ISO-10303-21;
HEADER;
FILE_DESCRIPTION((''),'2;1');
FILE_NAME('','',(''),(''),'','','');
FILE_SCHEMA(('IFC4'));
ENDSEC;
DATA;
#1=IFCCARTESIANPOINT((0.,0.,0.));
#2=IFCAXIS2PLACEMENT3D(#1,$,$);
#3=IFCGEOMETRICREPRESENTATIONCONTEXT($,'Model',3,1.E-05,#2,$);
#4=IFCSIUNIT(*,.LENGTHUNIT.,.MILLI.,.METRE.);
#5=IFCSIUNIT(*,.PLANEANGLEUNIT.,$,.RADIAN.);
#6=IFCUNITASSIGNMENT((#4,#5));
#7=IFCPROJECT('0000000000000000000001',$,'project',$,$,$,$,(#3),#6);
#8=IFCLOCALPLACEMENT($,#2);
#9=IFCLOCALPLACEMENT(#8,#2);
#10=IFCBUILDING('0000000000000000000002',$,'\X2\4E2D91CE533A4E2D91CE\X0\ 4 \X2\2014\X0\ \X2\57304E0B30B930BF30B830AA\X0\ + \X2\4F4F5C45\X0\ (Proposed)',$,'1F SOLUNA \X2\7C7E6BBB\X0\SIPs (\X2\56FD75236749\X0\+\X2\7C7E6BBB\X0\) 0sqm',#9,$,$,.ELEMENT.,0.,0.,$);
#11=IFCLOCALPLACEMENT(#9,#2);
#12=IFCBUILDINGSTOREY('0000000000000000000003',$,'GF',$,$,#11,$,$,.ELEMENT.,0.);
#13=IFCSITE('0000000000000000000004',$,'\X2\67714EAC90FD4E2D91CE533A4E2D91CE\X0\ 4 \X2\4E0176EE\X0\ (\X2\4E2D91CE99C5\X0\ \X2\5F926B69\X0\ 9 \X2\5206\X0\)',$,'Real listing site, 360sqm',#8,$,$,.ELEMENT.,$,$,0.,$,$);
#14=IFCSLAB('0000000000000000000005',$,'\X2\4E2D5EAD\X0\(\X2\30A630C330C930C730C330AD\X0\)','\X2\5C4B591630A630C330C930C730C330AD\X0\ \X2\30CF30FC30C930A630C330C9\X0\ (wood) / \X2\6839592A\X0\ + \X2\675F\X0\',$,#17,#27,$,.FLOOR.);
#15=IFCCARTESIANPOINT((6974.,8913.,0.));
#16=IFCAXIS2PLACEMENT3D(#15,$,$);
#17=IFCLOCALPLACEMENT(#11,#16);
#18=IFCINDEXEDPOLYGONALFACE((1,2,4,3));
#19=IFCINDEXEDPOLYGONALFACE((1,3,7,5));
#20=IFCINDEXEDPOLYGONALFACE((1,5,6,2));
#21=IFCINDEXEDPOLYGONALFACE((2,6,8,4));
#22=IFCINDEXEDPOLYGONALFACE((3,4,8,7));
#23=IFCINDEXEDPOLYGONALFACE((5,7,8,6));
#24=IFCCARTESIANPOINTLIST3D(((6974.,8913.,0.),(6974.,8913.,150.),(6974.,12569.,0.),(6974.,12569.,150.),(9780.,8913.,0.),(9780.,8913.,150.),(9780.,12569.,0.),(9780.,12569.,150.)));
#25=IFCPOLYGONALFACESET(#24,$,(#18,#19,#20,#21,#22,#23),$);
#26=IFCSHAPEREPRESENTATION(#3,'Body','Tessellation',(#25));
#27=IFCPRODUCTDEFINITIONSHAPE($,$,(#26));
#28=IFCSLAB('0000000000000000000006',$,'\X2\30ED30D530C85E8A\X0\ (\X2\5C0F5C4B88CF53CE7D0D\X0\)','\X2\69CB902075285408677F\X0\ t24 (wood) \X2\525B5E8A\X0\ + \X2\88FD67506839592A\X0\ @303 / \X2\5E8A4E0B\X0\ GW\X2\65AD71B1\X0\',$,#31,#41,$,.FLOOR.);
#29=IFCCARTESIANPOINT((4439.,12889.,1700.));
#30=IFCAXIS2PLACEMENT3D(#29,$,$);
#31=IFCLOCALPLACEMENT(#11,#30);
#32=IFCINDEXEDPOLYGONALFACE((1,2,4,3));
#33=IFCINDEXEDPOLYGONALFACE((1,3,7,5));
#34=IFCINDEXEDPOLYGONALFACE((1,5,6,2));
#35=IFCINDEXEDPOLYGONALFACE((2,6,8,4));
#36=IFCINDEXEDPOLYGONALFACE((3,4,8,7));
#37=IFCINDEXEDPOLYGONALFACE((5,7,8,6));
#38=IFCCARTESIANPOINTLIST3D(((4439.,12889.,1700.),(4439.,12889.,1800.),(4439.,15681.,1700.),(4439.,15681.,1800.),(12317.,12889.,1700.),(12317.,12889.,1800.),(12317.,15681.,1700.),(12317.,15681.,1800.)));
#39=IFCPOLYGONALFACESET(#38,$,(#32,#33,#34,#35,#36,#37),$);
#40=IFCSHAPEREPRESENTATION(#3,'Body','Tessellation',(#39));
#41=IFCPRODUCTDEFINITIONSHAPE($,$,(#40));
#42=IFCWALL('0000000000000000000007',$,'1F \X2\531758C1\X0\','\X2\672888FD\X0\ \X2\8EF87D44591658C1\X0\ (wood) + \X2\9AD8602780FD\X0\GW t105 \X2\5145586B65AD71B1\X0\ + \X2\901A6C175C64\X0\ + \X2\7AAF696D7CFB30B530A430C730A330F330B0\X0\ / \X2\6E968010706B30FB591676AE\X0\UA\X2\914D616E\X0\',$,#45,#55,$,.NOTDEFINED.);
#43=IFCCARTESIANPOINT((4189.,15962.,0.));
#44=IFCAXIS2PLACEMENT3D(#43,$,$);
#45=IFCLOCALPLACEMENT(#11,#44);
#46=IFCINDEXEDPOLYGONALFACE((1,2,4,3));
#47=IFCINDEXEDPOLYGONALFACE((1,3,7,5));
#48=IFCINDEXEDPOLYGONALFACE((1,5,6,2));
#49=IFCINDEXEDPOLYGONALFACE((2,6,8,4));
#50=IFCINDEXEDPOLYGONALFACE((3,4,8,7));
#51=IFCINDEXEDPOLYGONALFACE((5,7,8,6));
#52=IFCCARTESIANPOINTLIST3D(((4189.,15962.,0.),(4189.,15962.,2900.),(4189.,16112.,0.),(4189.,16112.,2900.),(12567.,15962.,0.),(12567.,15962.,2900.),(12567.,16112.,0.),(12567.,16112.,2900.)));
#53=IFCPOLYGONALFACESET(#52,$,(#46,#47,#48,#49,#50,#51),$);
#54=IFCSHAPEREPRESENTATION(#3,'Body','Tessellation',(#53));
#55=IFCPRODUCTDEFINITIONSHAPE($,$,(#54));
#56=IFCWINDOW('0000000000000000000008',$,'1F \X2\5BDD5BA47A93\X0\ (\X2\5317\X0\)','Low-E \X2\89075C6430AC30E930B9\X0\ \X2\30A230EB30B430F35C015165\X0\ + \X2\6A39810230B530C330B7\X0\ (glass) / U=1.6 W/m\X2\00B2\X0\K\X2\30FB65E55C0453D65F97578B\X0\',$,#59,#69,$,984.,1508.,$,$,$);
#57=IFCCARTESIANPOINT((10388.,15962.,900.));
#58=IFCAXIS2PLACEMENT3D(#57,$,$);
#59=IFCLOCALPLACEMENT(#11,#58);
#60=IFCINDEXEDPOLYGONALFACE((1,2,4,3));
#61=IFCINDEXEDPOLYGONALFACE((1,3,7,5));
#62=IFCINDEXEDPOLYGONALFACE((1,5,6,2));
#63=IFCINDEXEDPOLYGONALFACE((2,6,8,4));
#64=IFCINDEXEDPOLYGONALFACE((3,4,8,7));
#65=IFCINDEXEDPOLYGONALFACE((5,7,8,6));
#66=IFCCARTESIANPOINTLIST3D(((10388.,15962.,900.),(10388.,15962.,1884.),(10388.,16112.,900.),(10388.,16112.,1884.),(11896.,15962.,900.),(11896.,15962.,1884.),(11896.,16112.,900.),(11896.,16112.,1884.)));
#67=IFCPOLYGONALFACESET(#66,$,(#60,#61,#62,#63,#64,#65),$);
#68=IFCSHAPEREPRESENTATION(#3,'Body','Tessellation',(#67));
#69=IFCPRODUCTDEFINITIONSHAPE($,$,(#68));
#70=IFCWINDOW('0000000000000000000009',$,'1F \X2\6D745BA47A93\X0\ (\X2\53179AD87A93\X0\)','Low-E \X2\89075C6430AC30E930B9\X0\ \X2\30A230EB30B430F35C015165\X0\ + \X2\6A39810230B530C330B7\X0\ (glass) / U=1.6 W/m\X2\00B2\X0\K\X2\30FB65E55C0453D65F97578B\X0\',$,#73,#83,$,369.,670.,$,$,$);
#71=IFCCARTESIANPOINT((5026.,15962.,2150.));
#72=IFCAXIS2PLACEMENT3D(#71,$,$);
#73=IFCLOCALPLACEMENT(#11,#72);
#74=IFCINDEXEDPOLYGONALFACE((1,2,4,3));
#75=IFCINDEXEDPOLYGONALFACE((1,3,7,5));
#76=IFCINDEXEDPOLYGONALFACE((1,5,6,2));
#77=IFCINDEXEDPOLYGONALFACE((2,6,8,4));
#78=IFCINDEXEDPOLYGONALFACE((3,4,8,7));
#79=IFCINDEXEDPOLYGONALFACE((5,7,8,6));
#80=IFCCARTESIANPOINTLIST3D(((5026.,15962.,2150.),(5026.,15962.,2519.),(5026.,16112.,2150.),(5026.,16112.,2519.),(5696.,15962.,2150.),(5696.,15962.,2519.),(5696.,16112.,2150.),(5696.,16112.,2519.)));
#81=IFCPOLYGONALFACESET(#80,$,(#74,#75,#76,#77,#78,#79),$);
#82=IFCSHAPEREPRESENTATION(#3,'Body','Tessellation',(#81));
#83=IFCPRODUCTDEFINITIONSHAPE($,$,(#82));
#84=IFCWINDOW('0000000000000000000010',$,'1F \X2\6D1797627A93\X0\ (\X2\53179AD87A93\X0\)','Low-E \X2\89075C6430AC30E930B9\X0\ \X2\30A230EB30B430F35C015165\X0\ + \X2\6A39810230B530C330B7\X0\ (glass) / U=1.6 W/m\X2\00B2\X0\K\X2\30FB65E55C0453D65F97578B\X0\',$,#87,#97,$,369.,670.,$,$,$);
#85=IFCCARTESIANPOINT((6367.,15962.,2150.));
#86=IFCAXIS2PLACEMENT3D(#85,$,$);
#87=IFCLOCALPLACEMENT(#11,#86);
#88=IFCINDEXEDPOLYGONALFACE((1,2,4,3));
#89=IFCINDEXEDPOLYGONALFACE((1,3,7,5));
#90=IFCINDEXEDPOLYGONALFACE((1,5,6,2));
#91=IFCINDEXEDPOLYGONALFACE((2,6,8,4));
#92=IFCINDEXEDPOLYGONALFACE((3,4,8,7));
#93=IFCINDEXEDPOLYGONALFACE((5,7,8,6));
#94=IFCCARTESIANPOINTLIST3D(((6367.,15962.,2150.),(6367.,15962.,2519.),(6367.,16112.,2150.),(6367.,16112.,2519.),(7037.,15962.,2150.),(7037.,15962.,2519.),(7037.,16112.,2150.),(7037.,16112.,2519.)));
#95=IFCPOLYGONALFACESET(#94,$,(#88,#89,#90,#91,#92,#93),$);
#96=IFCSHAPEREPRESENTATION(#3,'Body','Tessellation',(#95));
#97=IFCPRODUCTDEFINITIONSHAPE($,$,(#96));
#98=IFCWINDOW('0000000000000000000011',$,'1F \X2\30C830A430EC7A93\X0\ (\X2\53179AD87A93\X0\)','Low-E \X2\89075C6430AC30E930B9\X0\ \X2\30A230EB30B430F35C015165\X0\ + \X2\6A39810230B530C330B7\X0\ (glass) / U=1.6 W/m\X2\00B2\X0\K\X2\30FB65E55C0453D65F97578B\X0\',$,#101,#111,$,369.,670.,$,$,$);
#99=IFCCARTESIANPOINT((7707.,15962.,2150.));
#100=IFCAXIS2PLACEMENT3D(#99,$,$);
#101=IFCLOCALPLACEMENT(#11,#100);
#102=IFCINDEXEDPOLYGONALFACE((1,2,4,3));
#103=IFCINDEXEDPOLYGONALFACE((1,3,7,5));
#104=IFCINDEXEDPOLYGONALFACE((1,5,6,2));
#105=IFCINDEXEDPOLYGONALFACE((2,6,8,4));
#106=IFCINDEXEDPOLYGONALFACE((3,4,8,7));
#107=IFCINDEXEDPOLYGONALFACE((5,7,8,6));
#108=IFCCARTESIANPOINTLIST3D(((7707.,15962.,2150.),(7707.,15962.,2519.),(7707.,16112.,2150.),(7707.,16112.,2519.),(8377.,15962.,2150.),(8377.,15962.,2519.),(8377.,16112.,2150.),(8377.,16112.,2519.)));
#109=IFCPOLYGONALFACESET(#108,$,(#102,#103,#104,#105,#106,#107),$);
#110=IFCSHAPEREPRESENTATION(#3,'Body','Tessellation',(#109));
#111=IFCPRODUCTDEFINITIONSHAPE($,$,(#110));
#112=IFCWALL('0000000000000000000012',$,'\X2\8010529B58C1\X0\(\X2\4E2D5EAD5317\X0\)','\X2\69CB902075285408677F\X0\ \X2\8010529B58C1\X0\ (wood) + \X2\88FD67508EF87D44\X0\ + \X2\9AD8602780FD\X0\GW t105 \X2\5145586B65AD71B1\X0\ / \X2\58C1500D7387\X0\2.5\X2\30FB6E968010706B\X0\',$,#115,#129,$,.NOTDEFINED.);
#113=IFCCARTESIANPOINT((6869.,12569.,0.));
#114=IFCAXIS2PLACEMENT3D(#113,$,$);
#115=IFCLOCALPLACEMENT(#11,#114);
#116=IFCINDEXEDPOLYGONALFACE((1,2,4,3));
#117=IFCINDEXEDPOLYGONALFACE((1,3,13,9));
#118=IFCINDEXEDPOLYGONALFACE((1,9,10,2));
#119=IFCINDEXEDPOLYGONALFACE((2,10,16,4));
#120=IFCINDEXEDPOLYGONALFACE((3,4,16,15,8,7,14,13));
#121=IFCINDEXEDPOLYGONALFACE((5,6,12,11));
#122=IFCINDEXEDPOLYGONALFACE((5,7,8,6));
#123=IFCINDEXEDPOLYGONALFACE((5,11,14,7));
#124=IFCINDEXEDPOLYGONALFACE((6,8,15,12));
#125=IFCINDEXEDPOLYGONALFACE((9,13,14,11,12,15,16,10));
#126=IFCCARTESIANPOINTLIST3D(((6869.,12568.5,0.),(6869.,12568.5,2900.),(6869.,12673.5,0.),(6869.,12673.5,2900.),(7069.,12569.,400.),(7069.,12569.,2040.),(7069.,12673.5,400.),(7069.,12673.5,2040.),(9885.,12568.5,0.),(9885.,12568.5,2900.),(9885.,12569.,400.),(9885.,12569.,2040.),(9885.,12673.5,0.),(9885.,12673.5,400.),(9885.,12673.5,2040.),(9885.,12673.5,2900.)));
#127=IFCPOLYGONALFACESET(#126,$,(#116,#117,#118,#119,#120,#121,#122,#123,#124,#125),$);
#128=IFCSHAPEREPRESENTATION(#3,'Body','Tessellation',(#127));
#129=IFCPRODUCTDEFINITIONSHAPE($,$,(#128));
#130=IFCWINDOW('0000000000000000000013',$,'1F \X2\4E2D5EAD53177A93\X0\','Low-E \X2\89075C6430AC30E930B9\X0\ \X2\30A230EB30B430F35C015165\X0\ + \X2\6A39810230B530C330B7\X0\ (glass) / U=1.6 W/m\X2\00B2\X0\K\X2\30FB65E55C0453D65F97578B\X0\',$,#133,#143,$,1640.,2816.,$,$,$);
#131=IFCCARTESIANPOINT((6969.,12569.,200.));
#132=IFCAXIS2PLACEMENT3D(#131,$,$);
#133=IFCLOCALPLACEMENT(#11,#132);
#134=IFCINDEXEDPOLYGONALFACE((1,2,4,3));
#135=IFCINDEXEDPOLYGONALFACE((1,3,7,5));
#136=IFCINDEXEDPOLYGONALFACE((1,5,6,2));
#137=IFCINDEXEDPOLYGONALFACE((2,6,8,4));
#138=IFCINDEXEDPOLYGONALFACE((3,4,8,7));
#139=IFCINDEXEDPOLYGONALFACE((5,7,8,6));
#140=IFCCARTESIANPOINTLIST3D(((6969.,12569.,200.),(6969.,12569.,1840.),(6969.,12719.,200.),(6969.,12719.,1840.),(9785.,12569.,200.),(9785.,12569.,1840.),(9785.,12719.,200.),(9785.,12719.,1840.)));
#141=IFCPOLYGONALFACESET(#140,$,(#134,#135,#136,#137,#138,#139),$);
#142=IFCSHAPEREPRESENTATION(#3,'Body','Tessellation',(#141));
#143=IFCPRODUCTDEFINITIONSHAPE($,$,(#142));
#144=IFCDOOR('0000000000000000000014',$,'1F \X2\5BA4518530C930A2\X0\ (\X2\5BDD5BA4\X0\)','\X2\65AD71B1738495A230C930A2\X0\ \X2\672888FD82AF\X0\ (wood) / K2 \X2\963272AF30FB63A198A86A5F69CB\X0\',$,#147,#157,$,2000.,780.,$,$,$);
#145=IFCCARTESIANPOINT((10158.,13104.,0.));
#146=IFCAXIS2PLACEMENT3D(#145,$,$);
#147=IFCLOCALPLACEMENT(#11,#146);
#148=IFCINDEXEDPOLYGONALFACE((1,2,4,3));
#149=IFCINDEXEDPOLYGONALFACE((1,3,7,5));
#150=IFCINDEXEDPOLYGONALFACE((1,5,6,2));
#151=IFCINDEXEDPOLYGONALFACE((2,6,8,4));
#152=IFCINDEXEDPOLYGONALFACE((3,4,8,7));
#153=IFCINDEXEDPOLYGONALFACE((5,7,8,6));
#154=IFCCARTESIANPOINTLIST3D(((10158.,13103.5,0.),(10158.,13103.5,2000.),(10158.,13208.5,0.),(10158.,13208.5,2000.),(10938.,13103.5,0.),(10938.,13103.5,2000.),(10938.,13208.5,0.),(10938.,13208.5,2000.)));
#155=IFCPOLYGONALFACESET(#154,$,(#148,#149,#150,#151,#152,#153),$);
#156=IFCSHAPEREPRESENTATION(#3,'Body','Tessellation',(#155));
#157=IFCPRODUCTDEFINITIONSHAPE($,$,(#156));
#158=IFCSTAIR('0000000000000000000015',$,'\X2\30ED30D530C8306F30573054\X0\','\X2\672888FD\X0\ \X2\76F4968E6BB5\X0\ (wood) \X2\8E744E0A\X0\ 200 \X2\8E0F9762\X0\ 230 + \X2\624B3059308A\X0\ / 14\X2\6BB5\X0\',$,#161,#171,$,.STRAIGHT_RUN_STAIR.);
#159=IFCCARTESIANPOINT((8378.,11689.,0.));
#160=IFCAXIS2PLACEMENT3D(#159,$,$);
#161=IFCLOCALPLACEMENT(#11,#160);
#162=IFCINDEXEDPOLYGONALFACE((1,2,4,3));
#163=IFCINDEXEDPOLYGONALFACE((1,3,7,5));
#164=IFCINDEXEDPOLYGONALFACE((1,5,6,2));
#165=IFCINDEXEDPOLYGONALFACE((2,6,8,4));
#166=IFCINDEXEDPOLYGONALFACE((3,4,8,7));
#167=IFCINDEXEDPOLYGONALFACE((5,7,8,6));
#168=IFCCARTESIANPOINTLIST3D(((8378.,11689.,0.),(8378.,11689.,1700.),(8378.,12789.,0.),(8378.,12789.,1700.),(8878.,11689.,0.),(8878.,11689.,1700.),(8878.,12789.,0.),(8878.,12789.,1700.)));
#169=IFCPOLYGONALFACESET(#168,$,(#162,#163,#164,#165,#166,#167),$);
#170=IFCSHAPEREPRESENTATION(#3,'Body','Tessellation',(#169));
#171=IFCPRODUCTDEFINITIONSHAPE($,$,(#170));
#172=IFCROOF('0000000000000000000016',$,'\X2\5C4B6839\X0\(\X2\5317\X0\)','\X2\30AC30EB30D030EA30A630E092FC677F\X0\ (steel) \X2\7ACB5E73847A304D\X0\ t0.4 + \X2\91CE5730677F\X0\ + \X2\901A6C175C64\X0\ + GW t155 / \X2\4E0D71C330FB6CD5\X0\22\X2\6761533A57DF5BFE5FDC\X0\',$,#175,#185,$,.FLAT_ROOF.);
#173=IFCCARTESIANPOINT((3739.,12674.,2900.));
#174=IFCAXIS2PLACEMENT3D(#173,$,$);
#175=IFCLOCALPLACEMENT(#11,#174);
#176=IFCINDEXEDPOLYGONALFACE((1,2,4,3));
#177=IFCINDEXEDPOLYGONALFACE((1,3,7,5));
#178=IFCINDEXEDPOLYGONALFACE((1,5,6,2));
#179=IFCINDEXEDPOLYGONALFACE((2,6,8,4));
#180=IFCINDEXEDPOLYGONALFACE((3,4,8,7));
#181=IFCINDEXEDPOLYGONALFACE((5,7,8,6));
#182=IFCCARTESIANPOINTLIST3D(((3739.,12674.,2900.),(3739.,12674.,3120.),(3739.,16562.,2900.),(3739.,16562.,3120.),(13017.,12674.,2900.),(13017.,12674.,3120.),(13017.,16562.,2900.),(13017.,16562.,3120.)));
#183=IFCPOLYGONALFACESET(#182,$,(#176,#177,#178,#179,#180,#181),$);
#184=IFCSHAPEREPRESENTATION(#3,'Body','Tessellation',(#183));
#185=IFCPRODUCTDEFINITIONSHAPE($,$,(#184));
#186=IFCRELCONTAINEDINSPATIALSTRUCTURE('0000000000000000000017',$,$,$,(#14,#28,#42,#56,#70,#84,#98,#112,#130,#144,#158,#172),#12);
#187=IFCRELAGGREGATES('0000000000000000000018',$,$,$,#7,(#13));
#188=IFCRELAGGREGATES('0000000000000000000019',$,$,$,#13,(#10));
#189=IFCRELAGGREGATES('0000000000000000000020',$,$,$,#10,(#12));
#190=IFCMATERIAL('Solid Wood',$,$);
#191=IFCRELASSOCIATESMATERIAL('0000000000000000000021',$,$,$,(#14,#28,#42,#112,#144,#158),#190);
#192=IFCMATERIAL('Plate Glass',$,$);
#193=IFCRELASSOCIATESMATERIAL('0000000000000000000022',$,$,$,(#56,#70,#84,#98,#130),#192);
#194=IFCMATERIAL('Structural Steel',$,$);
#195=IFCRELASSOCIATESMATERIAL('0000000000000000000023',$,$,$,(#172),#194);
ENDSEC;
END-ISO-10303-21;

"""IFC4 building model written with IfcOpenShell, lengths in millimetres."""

from ifc_helpers import new_model, si_unit, frame, frame_2d, origin, place, context, project, spatial, rectangle, extrude, material, element, fill, save


model = new_model("IFC4")

# Units and contexts
model_context = context("Model", 3, precision=1e-05, world=origin())
ifc_project = project(units=[si_unit("LENGTHUNIT", "METRE", prefix="MILLI"), si_unit("PLANEANGLEUNIT", "RADIAN")], contexts=[model_context])

# Site, building, storey
site_placement = place(None, origin())
site = spatial("IfcSite", under=ifc_project, at=site_placement, Name="東京都中野区中野 4 丁目 (中野駅 徒歩 9 分)", ObjectType="Real listing site, 360sqm", CompositionType="ELEMENT", RefElevation=0.0)
building_placement = place(site_placement, origin())
building = spatial("IfcBuilding", under=site, at=building_placement, Name="中野区中野 4 — 地下スタジオ + 住居 (Proposed)", ObjectType="1F SOLUNA 籾殻SIPs (国産杉+籾殻) 0sqm", CompositionType="ELEMENT", ElevationOfRefHeight=0.0, ElevationOfTerrain=0.0)
storey_placement = place(building_placement, origin())
storey = spatial("IfcBuildingStorey", under=building, at=storey_placement, Name="GF", CompositionType="ELEMENT", Elevation=0.0)

# Slabs
ifc_material_1 = material(Name="Solid Wood")
slab_1_placement = place(storey_placement, frame((6974.0, 8913.0, 0.0)))
element("IfcSlab", 1, at=slab_1_placement, inside=storey, material=ifc_material_1, Name="中庭(ウッドデッキ)", Description="屋外ウッドデッキ ハードウッド (wood) / 根太 + 束", PredefinedType="FLOOR", context=model_context, shape_type="SweptSolid", body=[
    extrude(rectangle(XDim=2806.0, YDim=3656.0, at=frame_2d((1403.0, 1828.0))), frame((6974.0, 8913.0, 0.0)), (0.0, 0.0, 1.0), 150.0),
])
slab_2_placement = place(storey_placement, frame((4439.0, 12889.0, 1700.0)))
element("IfcSlab", 2, at=slab_2_placement, inside=storey, material=ifc_material_1, Name="ロフト床 (小屋裏収納)", Description="構造用合板 t24 (wood) 剛床 + 製材根太 @303 / 床下 GW断熱", PredefinedType="FLOOR", context=model_context, shape_type="SweptSolid", body=[
    extrude(rectangle(XDim=7878.0, YDim=2792.0, at=frame_2d((3939.0, 1396.0))), frame((4439.0, 12889.0, 1700.0)), (0.0, 0.0, 1.0), 100.0),
])

# Wall, openings, windows
wall_1_placement = place(storey_placement, frame((4189.0, 15962.0, 0.0)))
wall_1 = element("IfcWall", 3, at=wall_1_placement, inside=storey, material=ifc_material_1, Name="1F 北壁", Description="木製 軸組外壁 (wood) + 高性能GW t105 充填断熱 + 通気層 + 窯業系サイディング / 準耐火・外皮UA配慮", PredefinedType="NOTDEFINED", context=model_context, shape_type="SweptSolid", body=[
    extrude(rectangle(XDim=8378.0, YDim=150.0, at=frame_2d((4189.0, 75.0))), frame((4189.0, 15962.0, 0.0)), (0.0, 0.0, 1.0), 2900.0),
])
opening_1_placement = place(storey_placement, frame((10388.0, 15962.0, 900.0)))
opening_1 = element("IfcOpeningElement", 4, at=opening_1_placement, cuts=wall_1, PredefinedType="NOTDEFINED", context=model_context, shape_type="SweptSolid", body=[
    extrude(rectangle(XDim=1508.0, YDim=150.0, at=frame_2d((754.0, 75.0))), frame((10388.0, 15962.0, 900.0)), (0.0, 0.0, 1.0), 984.0),
])
opening_2_placement = place(storey_placement, frame((5026.0, 15962.0, 2150.0)))
opening_2 = element("IfcOpeningElement", 5, at=opening_2_placement, cuts=wall_1, PredefinedType="NOTDEFINED", context=model_context, shape_type="SweptSolid", body=[
    extrude(rectangle(XDim=670.0, YDim=150.0, at=frame_2d((335.0, 75.0))), frame((5026.0, 15962.0, 2150.0)), (0.0, 0.0, 1.0), 369.0),
])
opening_3_placement = place(storey_placement, frame((6367.0, 15962.0, 2150.0)))
opening_3 = element("IfcOpeningElement", 6, at=opening_3_placement, cuts=wall_1, PredefinedType="NOTDEFINED", context=model_context, shape_type="SweptSolid", body=[
    extrude(rectangle(XDim=670.0, YDim=150.0, at=frame_2d((335.0, 75.0))), frame((6367.0, 15962.0, 2150.0)), (0.0, 0.0, 1.0), 369.0),
])
opening_4_placement = place(storey_placement, frame((7707.0, 15962.0, 2150.0)))
opening_4 = element("IfcOpeningElement", 7, at=opening_4_placement, cuts=wall_1, PredefinedType="NOTDEFINED", context=model_context, shape_type="SweptSolid", body=[
    extrude(rectangle(XDim=670.0, YDim=150.0, at=frame_2d((335.0, 75.0))), frame((7707.0, 15962.0, 2150.0)), (0.0, 0.0, 1.0), 369.0),
])
ifc_material_2 = material(Name="Plate Glass")
window_1_placement = place(storey_placement, frame((10388.0, 15962.0, 900.0)))
window_1 = element("IfcWindow", 8, at=window_1_placement, inside=storey, material=ifc_material_2, Name="1F 寝室窓 (北)", Description="Low-E 複層ガラス アルゴン封入 + 樹脂サッシ (glass) / U=1.6 W/m²K・日射取得型", OverallHeight=984.0, OverallWidth=1508.0, context=model_context, shape_type="SweptSolid", body=[
    extrude(rectangle(XDim=1508.0, YDim=150.0, at=frame_2d((754.0, 75.0))), frame((10388.0, 15962.0, 900.0)), (0.0, 0.0, 1.0), 984.0),
])
fill(opening_1, window_1)
window_2_placement = place(storey_placement, frame((5026.0, 15962.0, 2150.0)))
window_2 = element("IfcWindow", 9, at=window_2_placement, inside=storey, material=ifc_material_2, Name="1F 浴室窓 (北高窓)", Description="Low-E 複層ガラス アルゴン封入 + 樹脂サッシ (glass) / U=1.6 W/m²K・日射取得型", OverallHeight=369.0, OverallWidth=670.0, context=model_context, shape_type="SweptSolid", body=[
    extrude(rectangle(XDim=670.0, YDim=150.0, at=frame_2d((335.0, 75.0))), frame((5026.0, 15962.0, 2150.0)), (0.0, 0.0, 1.0), 369.0),
])
fill(opening_2, window_2)
window_3_placement = place(storey_placement, frame((6367.0, 15962.0, 2150.0)))
window_3 = element("IfcWindow", 10, at=window_3_placement, inside=storey, material=ifc_material_2, Name="1F 洗面窓 (北高窓)", Description="Low-E 複層ガラス アルゴン封入 + 樹脂サッシ (glass) / U=1.6 W/m²K・日射取得型", OverallHeight=369.0, OverallWidth=670.0, context=model_context, shape_type="SweptSolid", body=[
    extrude(rectangle(XDim=670.0, YDim=150.0, at=frame_2d((335.0, 75.0))), frame((6367.0, 15962.0, 2150.0)), (0.0, 0.0, 1.0), 369.0),
])
fill(opening_3, window_3)
window_4_placement = place(storey_placement, frame((7707.0, 15962.0, 2150.0)))
window_4 = element("IfcWindow", 11, at=window_4_placement, inside=storey, material=ifc_material_2, Name="1F トイレ窓 (北高窓)", Description="Low-E 複層ガラス アルゴン封入 + 樹脂サッシ (glass) / U=1.6 W/m²K・日射取得型", OverallHeight=369.0, OverallWidth=670.0, context=model_context, shape_type="SweptSolid", body=[
    extrude(rectangle(XDim=670.0, YDim=150.0, at=frame_2d((335.0, 75.0))), frame((7707.0, 15962.0, 2150.0)), (0.0, 0.0, 1.0), 369.0),
])
fill(opening_4, window_4)

# Wall, opening, window
wall_2_placement = place(storey_placement, frame((6869.0, 12569.0, 0.0)))
wall_2 = element("IfcWall", 12, at=wall_2_placement, inside=storey, material=ifc_material_1, Name="耐力壁(中庭北)", Description="構造用合板 耐力壁 (wood) + 製材軸組 + 高性能GW t105 充填断熱 / 壁倍率2.5・準耐火", PredefinedType="NOTDEFINED", context=model_context, shape_type="SweptSolid", body=[
    extrude(rectangle(XDim=3016.0, YDim=105.0, at=frame_2d((1508.0, 52.0))), frame((6869.0, 12569.0, 0.0)), (0.0, 0.0, 1.0), 2900.0),
])
opening_5_placement = place(storey_placement, frame((6969.0, 12569.0, 200.0)))
opening_5 = element("IfcOpeningElement", 13, at=opening_5_placement, cuts=wall_2, PredefinedType="NOTDEFINED", context=model_context, shape_type="SweptSolid", body=[
    extrude(rectangle(XDim=2816.0, YDim=150.0, at=frame_2d((1408.0, 75.0))), frame((6969.0, 12569.0, 200.0)), (0.0, 0.0, 1.0), 1640.0),
])
window_5_placement = place(storey_placement, frame((6969.0, 12569.0, 200.0)))
window_5 = element("IfcWindow", 14, at=window_5_placement, inside=storey, material=ifc_material_2, Name="1F 中庭北窓", Description="Low-E 複層ガラス アルゴン封入 + 樹脂サッシ (glass) / U=1.6 W/m²K・日射取得型", OverallHeight=1640.0, OverallWidth=2816.0, context=model_context, shape_type="SweptSolid", body=[
    extrude(rectangle(XDim=2816.0, YDim=150.0, at=frame_2d((1408.0, 75.0))), frame((6969.0, 12569.0, 200.0)), (0.0, 0.0, 1.0), 1640.0),
])
fill(opening_5, window_5)

# Door
door_1_placement = place(storey_placement, frame((10158.0, 13104.0, 0.0)))
element("IfcDoor", 15, at=door_1_placement, inside=storey, material=ifc_material_1, Name="1F 室内ドア (寝室)", Description="断熱玄関ドア 木製芯 (wood) / K2 防犯・採風機構", OverallHeight=2000.0, OverallWidth=780.0, context=model_context, shape_type="SweptSolid", body=[
    extrude(rectangle(XDim=780.0, YDim=105.0, at=frame_2d((390.0, 52.0))), frame((10158.0, 13104.0, 0.0)), (0.0, 0.0, 1.0), 2000.0),
])

# Stair
stair_placement = place(storey_placement, frame((8378.0, 11689.0, 0.0)))
element("IfcStair", 16, at=stair_placement, inside=storey, material=ifc_material_1, Name="ロフトはしご", Description="木製 直階段 (wood) 蹴上 200 踏面 230 + 手すり / 14段", PredefinedType="STRAIGHT_RUN_STAIR", context=model_context, shape_type="SweptSolid", body=[
    extrude(rectangle(XDim=500.0, YDim=1100.0, at=frame_2d((250.0, 550.0))), frame((8378.0, 11689.0, 0.0)), (0.0, 0.0, 1.0), 1700.0),
])

# Roof
ifc_material_3 = material(Name="Structural Steel")
roof_1_placement = place(storey_placement, frame((3739.0, 12674.0, 2900.0)))
element("IfcRoof", 17, at=roof_1_placement, inside=storey, material=ifc_material_3, Name="屋根(北)", Description="ガルバリウム鋼板 (steel) 立平葺き t0.4 + 野地板 + 通気層 + GW t155 / 不燃・法22条区域対応", PredefinedType="FLAT_ROOF", context=model_context, shape_type="SweptSolid", body=[
    extrude(rectangle(XDim=9278.0, YDim=3888.0, at=frame_2d((4639.0, 1944.0))), frame((3739.0, 12674.0, 2900.0)), (0.0, 0.0, 1.0), 220.0),
])

save(model, "model.ifc")
